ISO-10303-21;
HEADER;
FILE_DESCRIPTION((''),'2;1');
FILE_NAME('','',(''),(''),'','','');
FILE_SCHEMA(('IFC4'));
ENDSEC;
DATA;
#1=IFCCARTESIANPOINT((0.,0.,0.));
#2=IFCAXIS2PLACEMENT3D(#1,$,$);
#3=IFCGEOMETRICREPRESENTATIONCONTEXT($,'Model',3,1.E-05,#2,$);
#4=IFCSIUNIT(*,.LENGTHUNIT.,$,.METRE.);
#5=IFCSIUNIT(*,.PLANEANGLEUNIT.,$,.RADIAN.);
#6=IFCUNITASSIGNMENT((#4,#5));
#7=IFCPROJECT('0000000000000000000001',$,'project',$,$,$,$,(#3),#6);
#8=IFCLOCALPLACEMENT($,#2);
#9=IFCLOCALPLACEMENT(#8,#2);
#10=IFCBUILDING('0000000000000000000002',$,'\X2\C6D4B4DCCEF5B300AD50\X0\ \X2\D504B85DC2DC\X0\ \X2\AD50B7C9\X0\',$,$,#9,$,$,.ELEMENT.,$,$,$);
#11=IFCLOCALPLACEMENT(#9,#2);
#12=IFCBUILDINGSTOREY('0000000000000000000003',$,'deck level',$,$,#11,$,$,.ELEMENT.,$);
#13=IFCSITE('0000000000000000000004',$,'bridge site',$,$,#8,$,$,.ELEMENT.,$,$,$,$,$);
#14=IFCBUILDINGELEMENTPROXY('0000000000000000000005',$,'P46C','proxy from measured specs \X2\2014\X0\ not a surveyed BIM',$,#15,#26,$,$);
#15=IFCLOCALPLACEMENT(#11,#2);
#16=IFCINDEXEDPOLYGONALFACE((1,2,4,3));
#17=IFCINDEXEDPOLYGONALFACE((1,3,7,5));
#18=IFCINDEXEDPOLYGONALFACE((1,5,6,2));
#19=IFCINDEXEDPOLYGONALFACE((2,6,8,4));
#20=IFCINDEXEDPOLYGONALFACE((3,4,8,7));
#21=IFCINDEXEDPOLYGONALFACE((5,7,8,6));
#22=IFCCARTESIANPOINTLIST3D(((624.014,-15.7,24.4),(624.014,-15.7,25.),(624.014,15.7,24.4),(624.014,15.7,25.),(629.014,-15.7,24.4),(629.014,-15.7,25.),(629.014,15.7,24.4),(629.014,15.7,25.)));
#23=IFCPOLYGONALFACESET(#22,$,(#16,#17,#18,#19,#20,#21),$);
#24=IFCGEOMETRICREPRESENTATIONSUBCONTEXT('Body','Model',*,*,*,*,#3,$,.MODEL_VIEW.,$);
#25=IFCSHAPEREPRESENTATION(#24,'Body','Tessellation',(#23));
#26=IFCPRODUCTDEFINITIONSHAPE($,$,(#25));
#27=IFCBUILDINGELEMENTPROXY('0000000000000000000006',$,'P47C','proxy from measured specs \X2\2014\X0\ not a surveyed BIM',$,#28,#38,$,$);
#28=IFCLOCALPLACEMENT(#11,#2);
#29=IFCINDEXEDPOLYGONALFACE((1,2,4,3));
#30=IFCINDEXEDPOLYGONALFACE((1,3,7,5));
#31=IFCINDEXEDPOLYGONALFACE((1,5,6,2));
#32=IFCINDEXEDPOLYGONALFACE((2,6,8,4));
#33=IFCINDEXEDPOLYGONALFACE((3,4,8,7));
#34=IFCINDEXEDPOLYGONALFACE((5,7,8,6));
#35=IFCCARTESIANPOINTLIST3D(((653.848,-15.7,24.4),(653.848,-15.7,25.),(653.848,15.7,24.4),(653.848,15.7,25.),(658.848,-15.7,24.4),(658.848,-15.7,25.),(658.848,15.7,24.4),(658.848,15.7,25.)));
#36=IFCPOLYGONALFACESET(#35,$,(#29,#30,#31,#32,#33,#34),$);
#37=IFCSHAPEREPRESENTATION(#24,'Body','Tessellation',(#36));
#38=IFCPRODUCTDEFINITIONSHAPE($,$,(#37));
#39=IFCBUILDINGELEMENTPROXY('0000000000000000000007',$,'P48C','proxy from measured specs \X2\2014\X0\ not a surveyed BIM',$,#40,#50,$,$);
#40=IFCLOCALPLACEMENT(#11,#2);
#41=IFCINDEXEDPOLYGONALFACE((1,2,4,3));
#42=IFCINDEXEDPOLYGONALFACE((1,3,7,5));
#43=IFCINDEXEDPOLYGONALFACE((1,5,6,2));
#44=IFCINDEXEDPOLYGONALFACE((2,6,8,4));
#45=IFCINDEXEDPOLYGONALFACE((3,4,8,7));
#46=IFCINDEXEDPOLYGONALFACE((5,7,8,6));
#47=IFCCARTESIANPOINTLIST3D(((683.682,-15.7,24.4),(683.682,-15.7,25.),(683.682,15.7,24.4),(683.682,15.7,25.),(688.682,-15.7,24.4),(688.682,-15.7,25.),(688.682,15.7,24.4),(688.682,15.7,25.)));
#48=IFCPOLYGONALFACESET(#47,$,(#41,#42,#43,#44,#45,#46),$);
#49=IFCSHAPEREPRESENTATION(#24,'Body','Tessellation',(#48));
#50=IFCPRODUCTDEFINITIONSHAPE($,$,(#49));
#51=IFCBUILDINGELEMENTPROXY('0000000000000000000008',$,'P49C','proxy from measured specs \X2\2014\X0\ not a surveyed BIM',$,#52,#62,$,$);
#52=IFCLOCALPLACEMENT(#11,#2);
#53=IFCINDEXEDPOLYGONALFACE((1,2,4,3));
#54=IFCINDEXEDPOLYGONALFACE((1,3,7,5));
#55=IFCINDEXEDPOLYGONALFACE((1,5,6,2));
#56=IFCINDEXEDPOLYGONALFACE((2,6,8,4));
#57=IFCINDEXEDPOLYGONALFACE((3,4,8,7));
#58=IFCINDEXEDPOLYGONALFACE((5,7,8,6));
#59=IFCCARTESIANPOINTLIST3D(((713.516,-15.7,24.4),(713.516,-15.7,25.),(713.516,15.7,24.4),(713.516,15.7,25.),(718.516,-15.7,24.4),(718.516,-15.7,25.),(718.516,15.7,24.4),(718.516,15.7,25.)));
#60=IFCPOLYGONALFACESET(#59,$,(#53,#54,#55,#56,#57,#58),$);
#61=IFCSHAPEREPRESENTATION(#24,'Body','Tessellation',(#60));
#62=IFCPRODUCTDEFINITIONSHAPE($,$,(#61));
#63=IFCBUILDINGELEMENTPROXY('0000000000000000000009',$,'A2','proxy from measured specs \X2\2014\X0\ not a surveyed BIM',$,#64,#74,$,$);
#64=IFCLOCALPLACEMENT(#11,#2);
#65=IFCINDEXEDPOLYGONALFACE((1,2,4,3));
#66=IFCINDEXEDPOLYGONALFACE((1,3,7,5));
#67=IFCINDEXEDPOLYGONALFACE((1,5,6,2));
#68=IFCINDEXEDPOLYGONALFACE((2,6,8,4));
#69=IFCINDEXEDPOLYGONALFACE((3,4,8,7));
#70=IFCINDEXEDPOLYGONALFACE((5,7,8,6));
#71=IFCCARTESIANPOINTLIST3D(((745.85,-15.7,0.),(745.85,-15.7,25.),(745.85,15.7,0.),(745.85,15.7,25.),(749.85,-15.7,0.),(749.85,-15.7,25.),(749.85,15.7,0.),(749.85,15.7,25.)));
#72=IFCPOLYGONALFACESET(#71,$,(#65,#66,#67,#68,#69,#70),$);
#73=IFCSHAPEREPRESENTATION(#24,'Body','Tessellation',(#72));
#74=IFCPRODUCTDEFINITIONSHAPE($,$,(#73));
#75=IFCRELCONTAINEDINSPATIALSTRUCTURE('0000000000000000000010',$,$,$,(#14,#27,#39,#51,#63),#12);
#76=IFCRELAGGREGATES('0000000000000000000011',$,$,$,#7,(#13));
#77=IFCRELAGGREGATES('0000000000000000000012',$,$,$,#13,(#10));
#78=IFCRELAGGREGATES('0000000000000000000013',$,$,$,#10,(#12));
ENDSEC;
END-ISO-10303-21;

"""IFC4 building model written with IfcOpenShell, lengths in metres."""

from ifc_helpers import new_model, si_unit, frame, origin, origin_2d, place, context, subcontext, project, spatial, rectangle, extrude, element, save


model = new_model("IFC4")

# Units and contexts
model_context = context("Model", 3, precision=1e-05, world=origin())
body_context = subcontext(model_context, "Body", "Model", "MODEL_VIEW")
ifc_project = project(units=[si_unit("LENGTHUNIT", "METRE"), si_unit("PLANEANGLEUNIT", "RADIAN")], contexts=[model_context])

# Site, building, storey
site_placement = place(None, origin())
site = spatial("IfcSite", under=ifc_project, at=site_placement, Name="bridge site", CompositionType="ELEMENT")
building_placement = place(site_placement, origin())
building = spatial("IfcBuilding", under=site, at=building_placement, Name="월드컵대교 프록시 교량", CompositionType="ELEMENT")
storey_placement = place(building_placement, origin())
storey = spatial("IfcBuildingStorey", under=building, at=storey_placement, Name="deck level", CompositionType="ELEMENT")

# Building element proxies
for number, where, name in (
    (1, (626.514, 0.0, 24.4), "P46C"),
    (2, (656.348, 0.0, 24.4), "P47C"),
    (3, (686.182, 0.0, 24.4), "P48C"),
    (4, (716.016, 0.0, 24.4), "P49C"),
):
    element("IfcBuildingElementProxy", number, at=place(storey_placement, frame(where)), inside=storey, Name=name, Description="proxy from measured specs — not a surveyed BIM", context=body_context, shape_type="SweptSolid", body=[
        extrude(rectangle(XDim=5.0, YDim=31.4, at=origin_2d()), origin(), (0.0, 0.0, 1.0), 0.6),
    ])
proxy_placement = place(storey_placement, frame((747.85, 0.0, 0.0)))
element("IfcBuildingElementProxy", 5, at=proxy_placement, inside=storey, Name="A2", Description="proxy from measured specs — not a surveyed BIM", context=body_context, shape_type="SweptSolid", body=[
    extrude(rectangle(XDim=4.0, YDim=31.4, at=origin_2d()), origin(), (0.0, 0.0, 1.0), 25.0),
])

save(model, "model.ifc")
